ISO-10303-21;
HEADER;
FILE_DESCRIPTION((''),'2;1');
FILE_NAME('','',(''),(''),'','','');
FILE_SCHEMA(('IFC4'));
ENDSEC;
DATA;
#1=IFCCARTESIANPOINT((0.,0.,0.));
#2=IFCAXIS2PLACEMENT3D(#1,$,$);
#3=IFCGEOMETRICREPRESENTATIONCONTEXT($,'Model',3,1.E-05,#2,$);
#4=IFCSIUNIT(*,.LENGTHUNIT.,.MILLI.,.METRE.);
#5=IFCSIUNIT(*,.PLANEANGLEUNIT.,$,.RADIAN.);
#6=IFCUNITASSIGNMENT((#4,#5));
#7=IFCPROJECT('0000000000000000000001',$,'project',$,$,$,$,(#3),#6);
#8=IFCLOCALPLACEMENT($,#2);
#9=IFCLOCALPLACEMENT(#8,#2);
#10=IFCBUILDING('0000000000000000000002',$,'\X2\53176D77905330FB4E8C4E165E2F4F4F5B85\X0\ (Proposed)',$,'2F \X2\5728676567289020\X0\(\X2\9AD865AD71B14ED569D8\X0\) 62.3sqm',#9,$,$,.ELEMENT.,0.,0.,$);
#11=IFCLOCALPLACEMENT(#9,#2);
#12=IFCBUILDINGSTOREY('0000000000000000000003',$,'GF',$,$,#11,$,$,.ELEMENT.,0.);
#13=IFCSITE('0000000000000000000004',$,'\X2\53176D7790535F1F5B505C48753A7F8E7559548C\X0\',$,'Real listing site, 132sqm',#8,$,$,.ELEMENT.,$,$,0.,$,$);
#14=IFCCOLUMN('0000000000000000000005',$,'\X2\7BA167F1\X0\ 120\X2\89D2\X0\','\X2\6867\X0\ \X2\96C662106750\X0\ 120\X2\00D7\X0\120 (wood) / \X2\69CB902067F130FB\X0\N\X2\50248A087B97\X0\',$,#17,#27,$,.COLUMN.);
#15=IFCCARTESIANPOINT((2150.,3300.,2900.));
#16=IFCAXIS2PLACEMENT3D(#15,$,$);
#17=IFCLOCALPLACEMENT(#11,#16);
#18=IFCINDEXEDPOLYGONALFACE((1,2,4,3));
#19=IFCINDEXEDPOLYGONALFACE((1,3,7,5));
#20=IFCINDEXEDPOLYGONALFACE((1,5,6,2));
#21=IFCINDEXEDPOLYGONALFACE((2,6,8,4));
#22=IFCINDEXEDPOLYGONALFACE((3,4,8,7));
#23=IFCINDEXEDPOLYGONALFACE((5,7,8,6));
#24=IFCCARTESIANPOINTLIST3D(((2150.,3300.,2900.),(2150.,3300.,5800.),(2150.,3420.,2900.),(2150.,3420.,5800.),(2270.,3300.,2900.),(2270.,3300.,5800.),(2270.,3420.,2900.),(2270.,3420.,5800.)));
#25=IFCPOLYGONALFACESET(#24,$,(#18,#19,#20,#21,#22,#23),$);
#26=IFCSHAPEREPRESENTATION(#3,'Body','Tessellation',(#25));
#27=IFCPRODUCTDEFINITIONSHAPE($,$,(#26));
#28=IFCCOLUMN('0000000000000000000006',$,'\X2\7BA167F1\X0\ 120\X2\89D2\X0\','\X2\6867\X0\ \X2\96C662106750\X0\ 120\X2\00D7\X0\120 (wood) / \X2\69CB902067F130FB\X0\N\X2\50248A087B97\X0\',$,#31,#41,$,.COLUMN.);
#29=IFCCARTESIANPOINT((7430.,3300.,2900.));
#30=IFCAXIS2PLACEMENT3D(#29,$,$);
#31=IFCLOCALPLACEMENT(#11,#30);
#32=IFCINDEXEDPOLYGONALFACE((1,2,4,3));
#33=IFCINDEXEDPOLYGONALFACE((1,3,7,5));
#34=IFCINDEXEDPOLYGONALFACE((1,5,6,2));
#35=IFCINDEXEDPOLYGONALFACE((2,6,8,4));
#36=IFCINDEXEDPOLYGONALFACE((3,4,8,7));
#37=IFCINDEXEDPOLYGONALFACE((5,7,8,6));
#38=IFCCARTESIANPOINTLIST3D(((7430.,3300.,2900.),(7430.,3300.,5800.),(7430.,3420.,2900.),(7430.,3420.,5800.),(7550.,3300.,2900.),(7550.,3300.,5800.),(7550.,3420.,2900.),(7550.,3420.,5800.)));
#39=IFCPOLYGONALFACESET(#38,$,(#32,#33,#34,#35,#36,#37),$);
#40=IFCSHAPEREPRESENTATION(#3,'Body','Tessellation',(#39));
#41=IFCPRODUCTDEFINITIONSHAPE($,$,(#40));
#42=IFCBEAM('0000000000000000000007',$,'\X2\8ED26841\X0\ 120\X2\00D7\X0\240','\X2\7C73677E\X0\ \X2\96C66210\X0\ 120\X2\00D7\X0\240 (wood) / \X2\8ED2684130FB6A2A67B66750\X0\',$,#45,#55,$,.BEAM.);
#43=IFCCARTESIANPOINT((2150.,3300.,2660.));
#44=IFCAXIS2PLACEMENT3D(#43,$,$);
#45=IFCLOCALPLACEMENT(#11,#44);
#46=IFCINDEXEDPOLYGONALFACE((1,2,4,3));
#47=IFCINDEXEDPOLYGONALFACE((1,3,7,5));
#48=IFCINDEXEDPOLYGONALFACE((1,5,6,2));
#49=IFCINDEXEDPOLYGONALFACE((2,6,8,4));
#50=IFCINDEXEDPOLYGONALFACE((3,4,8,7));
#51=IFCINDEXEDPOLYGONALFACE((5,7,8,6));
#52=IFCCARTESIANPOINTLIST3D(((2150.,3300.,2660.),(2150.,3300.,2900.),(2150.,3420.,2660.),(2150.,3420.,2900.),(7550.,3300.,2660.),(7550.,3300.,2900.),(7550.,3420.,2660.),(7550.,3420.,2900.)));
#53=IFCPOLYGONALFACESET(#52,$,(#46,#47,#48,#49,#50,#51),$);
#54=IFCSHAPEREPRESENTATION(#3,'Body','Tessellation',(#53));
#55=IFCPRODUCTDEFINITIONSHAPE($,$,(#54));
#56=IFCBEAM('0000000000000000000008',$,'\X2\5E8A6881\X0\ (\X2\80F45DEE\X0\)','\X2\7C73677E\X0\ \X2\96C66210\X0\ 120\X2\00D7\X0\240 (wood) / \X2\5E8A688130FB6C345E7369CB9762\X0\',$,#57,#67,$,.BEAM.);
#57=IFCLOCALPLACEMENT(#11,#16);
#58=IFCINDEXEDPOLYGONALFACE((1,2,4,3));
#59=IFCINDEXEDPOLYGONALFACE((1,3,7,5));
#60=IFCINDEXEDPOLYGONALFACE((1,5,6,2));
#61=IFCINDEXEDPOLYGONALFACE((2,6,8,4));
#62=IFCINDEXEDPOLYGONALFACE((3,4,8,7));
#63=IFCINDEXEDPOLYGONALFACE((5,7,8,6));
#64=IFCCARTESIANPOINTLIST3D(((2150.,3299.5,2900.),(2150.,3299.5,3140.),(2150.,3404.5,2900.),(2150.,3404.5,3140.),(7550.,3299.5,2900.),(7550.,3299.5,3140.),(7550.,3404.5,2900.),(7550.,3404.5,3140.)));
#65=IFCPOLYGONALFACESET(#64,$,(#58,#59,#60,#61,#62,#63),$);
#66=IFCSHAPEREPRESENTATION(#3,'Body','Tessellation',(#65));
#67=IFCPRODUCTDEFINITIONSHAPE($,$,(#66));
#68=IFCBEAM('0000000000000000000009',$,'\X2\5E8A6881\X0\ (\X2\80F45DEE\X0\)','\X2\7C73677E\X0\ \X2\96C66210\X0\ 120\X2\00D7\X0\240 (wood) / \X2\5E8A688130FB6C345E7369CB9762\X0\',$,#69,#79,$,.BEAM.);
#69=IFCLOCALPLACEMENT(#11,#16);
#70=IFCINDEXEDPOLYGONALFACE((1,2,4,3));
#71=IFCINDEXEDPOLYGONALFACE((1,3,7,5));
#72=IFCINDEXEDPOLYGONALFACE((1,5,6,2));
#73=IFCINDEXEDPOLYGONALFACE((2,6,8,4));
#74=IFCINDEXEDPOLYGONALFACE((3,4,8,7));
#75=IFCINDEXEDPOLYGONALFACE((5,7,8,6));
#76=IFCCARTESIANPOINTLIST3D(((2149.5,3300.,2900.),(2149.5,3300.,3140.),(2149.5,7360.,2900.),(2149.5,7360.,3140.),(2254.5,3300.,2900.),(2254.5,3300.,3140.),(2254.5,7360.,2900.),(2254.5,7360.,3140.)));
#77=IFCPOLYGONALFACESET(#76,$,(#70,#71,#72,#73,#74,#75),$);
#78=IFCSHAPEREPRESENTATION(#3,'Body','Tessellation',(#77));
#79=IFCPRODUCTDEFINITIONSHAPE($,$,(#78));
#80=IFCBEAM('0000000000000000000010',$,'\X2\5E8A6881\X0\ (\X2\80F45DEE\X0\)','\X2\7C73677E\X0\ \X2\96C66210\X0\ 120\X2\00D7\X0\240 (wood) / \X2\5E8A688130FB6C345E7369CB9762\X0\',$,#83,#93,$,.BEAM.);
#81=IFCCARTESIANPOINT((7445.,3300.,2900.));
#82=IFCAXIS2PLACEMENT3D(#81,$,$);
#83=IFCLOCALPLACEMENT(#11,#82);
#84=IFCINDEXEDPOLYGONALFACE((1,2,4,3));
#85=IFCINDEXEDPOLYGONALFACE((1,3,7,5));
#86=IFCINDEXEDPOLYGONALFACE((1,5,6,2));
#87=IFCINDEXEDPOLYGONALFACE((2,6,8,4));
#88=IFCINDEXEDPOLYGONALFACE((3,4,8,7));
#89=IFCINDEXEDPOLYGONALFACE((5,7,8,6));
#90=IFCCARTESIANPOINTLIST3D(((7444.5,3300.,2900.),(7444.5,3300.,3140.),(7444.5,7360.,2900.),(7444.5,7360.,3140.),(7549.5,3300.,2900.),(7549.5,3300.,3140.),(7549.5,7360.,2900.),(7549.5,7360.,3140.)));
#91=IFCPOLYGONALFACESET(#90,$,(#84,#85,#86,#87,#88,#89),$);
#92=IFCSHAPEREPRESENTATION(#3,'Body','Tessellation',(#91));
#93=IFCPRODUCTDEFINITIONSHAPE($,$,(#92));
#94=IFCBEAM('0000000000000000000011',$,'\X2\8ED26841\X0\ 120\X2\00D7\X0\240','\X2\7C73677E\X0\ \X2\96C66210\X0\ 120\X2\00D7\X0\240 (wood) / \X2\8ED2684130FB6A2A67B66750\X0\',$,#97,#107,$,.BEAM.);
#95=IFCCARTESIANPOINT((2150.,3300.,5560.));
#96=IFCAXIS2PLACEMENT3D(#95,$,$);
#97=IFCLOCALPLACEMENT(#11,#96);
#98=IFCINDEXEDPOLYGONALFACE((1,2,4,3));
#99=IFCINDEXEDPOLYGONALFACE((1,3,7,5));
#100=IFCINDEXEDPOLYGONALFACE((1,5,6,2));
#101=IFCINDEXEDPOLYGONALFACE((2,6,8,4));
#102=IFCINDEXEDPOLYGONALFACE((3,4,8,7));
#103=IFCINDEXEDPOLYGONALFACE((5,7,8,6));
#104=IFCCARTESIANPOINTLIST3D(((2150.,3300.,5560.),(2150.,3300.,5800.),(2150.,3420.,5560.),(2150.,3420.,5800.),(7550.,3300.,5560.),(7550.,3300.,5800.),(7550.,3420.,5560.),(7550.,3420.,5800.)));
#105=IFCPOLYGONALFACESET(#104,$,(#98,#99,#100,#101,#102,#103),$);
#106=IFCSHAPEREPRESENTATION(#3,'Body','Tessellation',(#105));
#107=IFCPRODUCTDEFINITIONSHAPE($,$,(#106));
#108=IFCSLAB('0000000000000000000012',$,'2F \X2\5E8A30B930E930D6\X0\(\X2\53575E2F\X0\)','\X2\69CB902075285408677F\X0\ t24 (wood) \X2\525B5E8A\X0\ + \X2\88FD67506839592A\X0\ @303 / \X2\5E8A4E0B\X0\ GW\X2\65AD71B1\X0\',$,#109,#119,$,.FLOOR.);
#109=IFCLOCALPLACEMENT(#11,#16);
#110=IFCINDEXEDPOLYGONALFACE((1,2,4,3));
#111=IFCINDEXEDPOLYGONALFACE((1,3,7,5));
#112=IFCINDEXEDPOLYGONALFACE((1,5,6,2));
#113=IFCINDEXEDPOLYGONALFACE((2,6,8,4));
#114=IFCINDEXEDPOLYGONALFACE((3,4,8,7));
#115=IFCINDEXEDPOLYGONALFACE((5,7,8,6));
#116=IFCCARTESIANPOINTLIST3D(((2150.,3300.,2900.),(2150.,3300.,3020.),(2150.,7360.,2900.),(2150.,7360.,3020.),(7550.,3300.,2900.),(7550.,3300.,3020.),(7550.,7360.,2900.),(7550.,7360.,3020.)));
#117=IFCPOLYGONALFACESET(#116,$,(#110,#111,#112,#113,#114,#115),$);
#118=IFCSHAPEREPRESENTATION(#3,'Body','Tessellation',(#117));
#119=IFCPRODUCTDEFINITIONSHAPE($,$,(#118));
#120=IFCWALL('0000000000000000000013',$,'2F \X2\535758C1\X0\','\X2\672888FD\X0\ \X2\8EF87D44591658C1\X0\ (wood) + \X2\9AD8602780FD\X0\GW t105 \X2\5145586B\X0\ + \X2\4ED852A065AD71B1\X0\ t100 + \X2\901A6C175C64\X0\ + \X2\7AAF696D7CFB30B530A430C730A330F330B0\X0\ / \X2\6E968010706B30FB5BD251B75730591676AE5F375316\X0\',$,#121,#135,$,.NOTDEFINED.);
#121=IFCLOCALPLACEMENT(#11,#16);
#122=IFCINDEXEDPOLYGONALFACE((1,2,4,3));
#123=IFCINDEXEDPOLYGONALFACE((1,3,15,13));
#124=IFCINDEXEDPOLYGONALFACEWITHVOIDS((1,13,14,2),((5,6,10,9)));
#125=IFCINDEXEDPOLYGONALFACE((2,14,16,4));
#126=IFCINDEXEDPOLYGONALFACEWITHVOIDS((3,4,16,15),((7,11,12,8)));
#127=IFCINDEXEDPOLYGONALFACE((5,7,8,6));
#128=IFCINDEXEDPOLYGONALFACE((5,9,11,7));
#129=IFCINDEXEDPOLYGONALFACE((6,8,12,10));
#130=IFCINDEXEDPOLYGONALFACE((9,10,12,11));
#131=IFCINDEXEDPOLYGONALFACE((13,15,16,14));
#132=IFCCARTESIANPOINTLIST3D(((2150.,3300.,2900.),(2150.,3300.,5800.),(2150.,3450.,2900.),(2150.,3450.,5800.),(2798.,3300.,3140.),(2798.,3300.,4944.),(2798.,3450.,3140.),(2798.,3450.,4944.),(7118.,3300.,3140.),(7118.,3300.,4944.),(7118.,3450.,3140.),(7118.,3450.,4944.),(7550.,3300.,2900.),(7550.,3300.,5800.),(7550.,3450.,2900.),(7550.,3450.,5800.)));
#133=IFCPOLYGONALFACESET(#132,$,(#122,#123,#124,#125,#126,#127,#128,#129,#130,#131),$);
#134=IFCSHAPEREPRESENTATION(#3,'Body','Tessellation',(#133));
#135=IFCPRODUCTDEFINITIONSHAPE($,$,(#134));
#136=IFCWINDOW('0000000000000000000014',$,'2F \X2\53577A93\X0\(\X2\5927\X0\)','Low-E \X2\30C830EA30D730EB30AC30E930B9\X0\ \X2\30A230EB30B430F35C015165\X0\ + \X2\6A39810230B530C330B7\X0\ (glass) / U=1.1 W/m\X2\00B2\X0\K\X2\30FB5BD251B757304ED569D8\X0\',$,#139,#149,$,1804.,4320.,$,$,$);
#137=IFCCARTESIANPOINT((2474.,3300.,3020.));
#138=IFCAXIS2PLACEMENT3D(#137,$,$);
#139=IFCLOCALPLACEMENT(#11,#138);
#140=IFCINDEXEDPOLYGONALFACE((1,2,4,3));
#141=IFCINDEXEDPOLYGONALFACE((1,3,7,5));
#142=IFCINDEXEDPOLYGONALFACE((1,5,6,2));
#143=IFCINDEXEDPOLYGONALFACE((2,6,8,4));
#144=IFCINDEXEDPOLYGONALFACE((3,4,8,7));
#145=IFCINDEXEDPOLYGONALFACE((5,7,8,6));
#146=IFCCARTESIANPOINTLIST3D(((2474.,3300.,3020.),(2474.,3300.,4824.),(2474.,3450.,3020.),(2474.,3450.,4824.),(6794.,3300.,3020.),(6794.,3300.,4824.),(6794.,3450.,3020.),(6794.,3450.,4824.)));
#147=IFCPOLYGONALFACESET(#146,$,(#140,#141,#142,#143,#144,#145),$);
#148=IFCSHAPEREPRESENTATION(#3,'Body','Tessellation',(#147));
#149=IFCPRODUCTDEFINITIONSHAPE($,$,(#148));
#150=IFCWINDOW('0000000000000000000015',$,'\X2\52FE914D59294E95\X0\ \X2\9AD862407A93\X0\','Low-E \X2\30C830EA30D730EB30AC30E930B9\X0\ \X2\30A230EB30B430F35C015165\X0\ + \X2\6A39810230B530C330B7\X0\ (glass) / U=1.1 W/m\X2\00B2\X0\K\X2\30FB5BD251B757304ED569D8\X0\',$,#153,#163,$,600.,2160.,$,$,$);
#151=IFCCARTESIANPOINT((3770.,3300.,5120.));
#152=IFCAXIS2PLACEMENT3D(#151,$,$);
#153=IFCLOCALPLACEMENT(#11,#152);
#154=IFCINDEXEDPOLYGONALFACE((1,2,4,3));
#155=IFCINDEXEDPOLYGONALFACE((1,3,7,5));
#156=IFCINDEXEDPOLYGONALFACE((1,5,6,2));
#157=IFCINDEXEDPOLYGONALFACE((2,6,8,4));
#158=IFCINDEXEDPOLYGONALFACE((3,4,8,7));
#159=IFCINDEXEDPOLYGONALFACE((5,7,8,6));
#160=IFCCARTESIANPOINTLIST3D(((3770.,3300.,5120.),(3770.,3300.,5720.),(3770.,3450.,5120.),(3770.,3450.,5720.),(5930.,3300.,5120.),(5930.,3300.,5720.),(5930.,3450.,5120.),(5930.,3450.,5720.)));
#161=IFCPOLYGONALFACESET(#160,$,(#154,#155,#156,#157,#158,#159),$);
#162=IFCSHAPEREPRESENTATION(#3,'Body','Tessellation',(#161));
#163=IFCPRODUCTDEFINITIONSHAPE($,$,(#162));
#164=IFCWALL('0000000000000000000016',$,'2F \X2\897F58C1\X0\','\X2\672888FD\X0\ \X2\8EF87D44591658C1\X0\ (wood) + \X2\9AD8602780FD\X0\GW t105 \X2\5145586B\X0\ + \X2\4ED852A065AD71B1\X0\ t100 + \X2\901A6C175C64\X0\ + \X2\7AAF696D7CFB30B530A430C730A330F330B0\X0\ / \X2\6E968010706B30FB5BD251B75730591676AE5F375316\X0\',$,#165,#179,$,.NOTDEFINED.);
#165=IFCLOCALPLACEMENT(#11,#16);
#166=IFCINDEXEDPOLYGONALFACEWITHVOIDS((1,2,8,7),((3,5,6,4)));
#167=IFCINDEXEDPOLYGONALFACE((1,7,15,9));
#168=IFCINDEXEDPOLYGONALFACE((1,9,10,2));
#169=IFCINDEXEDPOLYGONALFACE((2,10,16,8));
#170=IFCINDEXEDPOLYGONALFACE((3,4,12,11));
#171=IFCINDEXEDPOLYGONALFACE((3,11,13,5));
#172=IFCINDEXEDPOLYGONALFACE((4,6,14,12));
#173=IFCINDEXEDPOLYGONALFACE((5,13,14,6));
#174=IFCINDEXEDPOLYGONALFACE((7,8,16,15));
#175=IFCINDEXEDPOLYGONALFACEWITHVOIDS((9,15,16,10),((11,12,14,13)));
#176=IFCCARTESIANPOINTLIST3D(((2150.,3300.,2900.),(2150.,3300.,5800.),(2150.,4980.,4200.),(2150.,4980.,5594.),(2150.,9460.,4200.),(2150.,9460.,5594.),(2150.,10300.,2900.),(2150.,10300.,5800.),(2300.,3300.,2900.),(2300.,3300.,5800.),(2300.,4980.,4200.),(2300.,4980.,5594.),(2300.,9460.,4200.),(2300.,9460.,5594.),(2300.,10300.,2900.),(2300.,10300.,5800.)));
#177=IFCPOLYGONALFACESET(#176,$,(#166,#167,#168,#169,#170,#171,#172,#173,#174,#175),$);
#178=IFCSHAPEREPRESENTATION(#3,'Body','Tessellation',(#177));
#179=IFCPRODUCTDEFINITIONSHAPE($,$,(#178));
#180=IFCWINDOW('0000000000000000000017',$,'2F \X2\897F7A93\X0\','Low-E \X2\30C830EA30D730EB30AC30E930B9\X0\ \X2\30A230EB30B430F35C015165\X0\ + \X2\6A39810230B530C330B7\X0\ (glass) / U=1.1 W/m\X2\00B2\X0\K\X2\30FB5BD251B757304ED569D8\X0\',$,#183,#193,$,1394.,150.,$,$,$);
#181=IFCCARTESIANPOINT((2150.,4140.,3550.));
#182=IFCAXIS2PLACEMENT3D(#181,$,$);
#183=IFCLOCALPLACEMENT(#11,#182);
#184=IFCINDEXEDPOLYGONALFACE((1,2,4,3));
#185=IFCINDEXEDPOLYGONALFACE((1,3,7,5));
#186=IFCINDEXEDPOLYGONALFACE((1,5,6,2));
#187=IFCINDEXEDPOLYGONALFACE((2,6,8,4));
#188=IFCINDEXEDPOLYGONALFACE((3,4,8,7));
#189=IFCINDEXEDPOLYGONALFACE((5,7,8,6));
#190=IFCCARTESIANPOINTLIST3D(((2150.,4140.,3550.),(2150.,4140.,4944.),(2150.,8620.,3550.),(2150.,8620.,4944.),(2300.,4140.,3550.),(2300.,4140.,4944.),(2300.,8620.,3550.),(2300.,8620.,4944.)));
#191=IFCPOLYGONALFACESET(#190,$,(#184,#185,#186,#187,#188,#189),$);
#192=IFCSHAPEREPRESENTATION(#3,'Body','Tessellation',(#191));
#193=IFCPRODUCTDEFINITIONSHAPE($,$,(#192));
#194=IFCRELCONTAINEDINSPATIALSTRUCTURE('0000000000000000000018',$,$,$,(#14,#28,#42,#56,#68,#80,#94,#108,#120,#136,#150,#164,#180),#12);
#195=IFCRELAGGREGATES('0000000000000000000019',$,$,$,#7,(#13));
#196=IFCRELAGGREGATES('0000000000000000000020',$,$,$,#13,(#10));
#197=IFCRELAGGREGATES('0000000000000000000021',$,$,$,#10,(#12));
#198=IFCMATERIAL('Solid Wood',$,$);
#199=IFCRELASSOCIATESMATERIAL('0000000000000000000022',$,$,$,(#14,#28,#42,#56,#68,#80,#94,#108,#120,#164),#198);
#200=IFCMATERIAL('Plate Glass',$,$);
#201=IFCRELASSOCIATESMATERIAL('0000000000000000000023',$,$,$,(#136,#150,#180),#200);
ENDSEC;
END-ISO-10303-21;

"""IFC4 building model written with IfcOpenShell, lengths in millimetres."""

from ifc_helpers import new_model, si_unit, frame, frame_2d, origin, place, context, project, spatial, rectangle, extrude, material, element, fill, save


model = new_model("IFC4")

# Units and contexts
model_context = context("Model", 3, precision=1e-05, world=origin())
ifc_project = project(units=[si_unit("LENGTHUNIT", "METRE", prefix="MILLI"), si_unit("PLANEANGLEUNIT", "RADIAN")], contexts=[model_context])

# Site, building, storey
site_placement = place(None, origin())
site = spatial("IfcSite", under=ifc_project, at=site_placement, Name="北海道弟子屈町美留和", ObjectType="Real listing site, 132sqm", CompositionType="ELEMENT", RefElevation=0.0)
building_placement = place(site_placement, origin())
building = spatial("IfcBuilding", under=site, at=building_placement, Name="北海道・二世帯住宅 (Proposed)", ObjectType="2F 在来木造(高断熱仕様) 62.3sqm", CompositionType="ELEMENT", ElevationOfRefHeight=0.0, ElevationOfTerrain=0.0)
storey_placement = place(building_placement, origin())
storey = spatial("IfcBuildingStorey", under=building, at=storey_placement, Name="GF", CompositionType="ELEMENT", Elevation=0.0)

# Columns
ifc_material_1 = material(Name="Solid Wood")
column_1_placement = place(storey_placement, frame((2150.0, 3300.0, 2900.0)))
element("IfcColumn", 1, at=column_1_placement, inside=storey, material=ifc_material_1, Name="管柱 120角", Description="桧 集成材 120×120 (wood) / 構造柱・N値計算", PredefinedType="COLUMN", context=model_context, shape_type="SweptSolid", body=[
    extrude(rectangle(XDim=120.0, YDim=120.0, at=frame_2d((60.0, 60.0))), frame((2150.0, 3300.0, 2900.0)), (0.0, 0.0, 1.0), 2900.0),
])
column_2_placement = place(storey_placement, frame((7430.0, 3300.0, 2900.0)))
element("IfcColumn", 2, at=column_2_placement, inside=storey, material=ifc_material_1, Name="管柱 120角", Description="桧 集成材 120×120 (wood) / 構造柱・N値計算", PredefinedType="COLUMN", context=model_context, shape_type="SweptSolid", body=[
    extrude(rectangle(XDim=120.0, YDim=120.0, at=frame_2d((60.0, 60.0))), frame((7430.0, 3300.0, 2900.0)), (0.0, 0.0, 1.0), 2900.0),
])

# Beams
beam_1_placement = place(storey_placement, frame((2150.0, 3300.0, 2660.0)))
element("IfcBeam", 3, at=beam_1_placement, inside=storey, material=ifc_material_1, Name="軒桁 120×240", Description="米松 集成 120×240 (wood) / 軒桁・横架材", PredefinedType="BEAM", context=model_context, shape_type="SweptSolid", body=[
    extrude(rectangle(XDim=5400.0, YDim=120.0, at=frame_2d((2700.0, 60.0))), frame((2150.0, 3300.0, 2660.0)), (0.0, 0.0, 1.0), 240.0),
])
beam_2_placement = place(storey_placement, frame((2150.0, 3300.0, 2900.0)))
element("IfcBeam", 4, at=beam_2_placement, inside=storey, material=ifc_material_1, Name="床梁 (胴差)", Description="米松 集成 120×240 (wood) / 床梁・水平構面", PredefinedType="BEAM", context=model_context, shape_type="SweptSolid", body=[
    extrude(rectangle(XDim=5400.0, YDim=105.0, at=frame_2d((2700.0, 52.0))), frame((2150.0, 3300.0, 2900.0)), (0.0, 0.0, 1.0), 240.0),
])
beam_3_placement = place(storey_placement, frame((2150.0, 3300.0, 2900.0)))
element("IfcBeam", 5, at=beam_3_placement, inside=storey, material=ifc_material_1, Name="床梁 (胴差)", Description="米松 集成 120×240 (wood) / 床梁・水平構面", PredefinedType="BEAM", context=model_context, shape_type="SweptSolid", body=[
    extrude(rectangle(XDim=105.0, YDim=4060.0, at=frame_2d((52.0, 2030.0))), frame((2150.0, 3300.0, 2900.0)), (0.0, 0.0, 1.0), 240.0),
])
beam_4_placement = place(storey_placement, frame((7445.0, 3300.0, 2900.0)))
element("IfcBeam", 6, at=beam_4_placement, inside=storey, material=ifc_material_1, Name="床梁 (胴差)", Description="米松 集成 120×240 (wood) / 床梁・水平構面", PredefinedType="BEAM", context=model_context, shape_type="SweptSolid", body=[
    extrude(rectangle(XDim=105.0, YDim=4060.0, at=frame_2d((52.0, 2030.0))), frame((7445.0, 3300.0, 2900.0)), (0.0, 0.0, 1.0), 240.0),
])
beam_5_placement = place(storey_placement, frame((2150.0, 3300.0, 5560.0)))
element("IfcBeam", 7, at=beam_5_placement, inside=storey, material=ifc_material_1, Name="軒桁 120×240", Description="米松 集成 120×240 (wood) / 軒桁・横架材", PredefinedType="BEAM", context=model_context, shape_type="SweptSolid", body=[
    extrude(rectangle(XDim=5400.0, YDim=120.0, at=frame_2d((2700.0, 60.0))), frame((2150.0, 3300.0, 5560.0)), (0.0, 0.0, 1.0), 240.0),
])

# Slab
slab_placement = place(storey_placement, frame((2150.0, 3300.0, 2900.0)))
element("IfcSlab", 8, at=slab_placement, inside=storey, material=ifc_material_1, Name="2F 床スラブ(南帯)", Description="構造用合板 t24 (wood) 剛床 + 製材根太 @303 / 床下 GW断熱", PredefinedType="FLOOR", context=model_context, shape_type="SweptSolid", body=[
    extrude(rectangle(XDim=5400.0, YDim=4060.0, at=frame_2d((2700.0, 2030.0))), frame((2150.0, 3300.0, 2900.0)), (0.0, 0.0, 1.0), 120.0),
])

# Wall, openings, windows
wall_1_placement = place(storey_placement, frame((2150.0, 3300.0, 2900.0)))
wall_1 = element("IfcWall", 9, at=wall_1_placement, inside=storey, material=ifc_material_1, Name="2F 南壁", Description="木製 軸組外壁 (wood) + 高性能GW t105 充填 + 付加断熱 t100 + 通気層 + 窯業系サイディング / 準耐火・寒冷地外皮強化", PredefinedType="NOTDEFINED", context=model_context, shape_type="SweptSolid", body=[
    extrude(rectangle(XDim=5400.0, YDim=150.0, at=frame_2d((2700.0, 75.0))), frame((2150.0, 3300.0, 2900.0)), (0.0, 0.0, 1.0), 2900.0),
])
opening_1_placement = place(storey_placement, frame((2474.0, 3300.0, 3020.0)))
opening_1 = element("IfcOpeningElement", 10, at=opening_1_placement, cuts=wall_1, PredefinedType="NOTDEFINED", context=model_context, shape_type="SweptSolid", body=[
    extrude(rectangle(XDim=4320.0, YDim=150.0, at=frame_2d((2160.0, 75.0))), frame((2474.0, 3300.0, 3020.0)), (0.0, 0.0, 1.0), 1804.0),
])
opening_2_placement = place(storey_placement, frame((3770.0, 3300.0, 5120.0)))
opening_2 = element("IfcOpeningElement", 11, at=opening_2_placement, cuts=wall_1, PredefinedType="NOTDEFINED", context=model_context, shape_type="SweptSolid", body=[
    extrude(rectangle(XDim=2160.0, YDim=150.0, at=frame_2d((1080.0, 75.0))), frame((3770.0, 3300.0, 5120.0)), (0.0, 0.0, 1.0), 600.0),
])
ifc_material_2 = material(Name="Plate Glass")
window_1_placement = place(storey_placement, frame((2474.0, 3300.0, 3020.0)))
window_1 = element("IfcWindow", 12, at=window_1_placement, inside=storey, material=ifc_material_2, Name="2F 南窓(大)", Description="Low-E トリプルガラス アルゴン封入 + 樹脂サッシ (glass) / U=1.1 W/m²K・寒冷地仕様", OverallHeight=1804.0, OverallWidth=4320.0, context=model_context, shape_type="SweptSolid", body=[
    extrude(rectangle(XDim=4320.0, YDim=150.0, at=frame_2d((2160.0, 75.0))), frame((2474.0, 3300.0, 3020.0)), (0.0, 0.0, 1.0), 1804.0),
])
fill(opening_1, window_1)
window_2_placement = place(storey_placement, frame((3770.0, 3300.0, 5120.0)))
window_2 = element("IfcWindow", 13, at=window_2_placement, inside=storey, material=ifc_material_2, Name="勾配天井 高所窓", Description="Low-E トリプルガラス アルゴン封入 + 樹脂サッシ (glass) / U=1.1 W/m²K・寒冷地仕様", OverallHeight=600.0, OverallWidth=2160.0, context=model_context, shape_type="SweptSolid", body=[
    extrude(rectangle(XDim=2160.0, YDim=150.0, at=frame_2d((1080.0, 75.0))), frame((3770.0, 3300.0, 5120.0)), (0.0, 0.0, 1.0), 600.0),
])
fill(opening_2, window_2)

# Wall, opening, window
wall_2_placement = place(storey_placement, frame((2150.0, 3300.0, 2900.0)))
wall_2 = element("IfcWall", 14, at=wall_2_placement, inside=storey, material=ifc_material_1, Name="2F 西壁", Description="木製 軸組外壁 (wood) + 高性能GW t105 充填 + 付加断熱 t100 + 通気層 + 窯業系サイディング / 準耐火・寒冷地外皮強化", PredefinedType="NOTDEFINED", context=model_context, shape_type="SweptSolid", body=[
    extrude(rectangle(XDim=150.0, YDim=7000.0, at=frame_2d((75.0, 3500.0))), frame((2150.0, 3300.0, 2900.0)), (0.0, 0.0, 1.0), 2900.0),
])
opening_3_placement = place(storey_placement, frame((2150.0, 4140.0, 3550.0)))
opening_3 = element("IfcOpeningElement", 15, at=opening_3_placement, cuts=wall_2, PredefinedType="NOTDEFINED", context=model_context, shape_type="SweptSolid", body=[
    extrude(rectangle(XDim=150.0, YDim=4480.0, at=frame_2d((75.0, 2240.0))), frame((2150.0, 4140.0, 3550.0)), (0.0, 0.0, 1.0), 1394.0),
])
window_3_placement = place(storey_placement, frame((2150.0, 4140.0, 3550.0)))
window_3 = element("IfcWindow", 16, at=window_3_placement, inside=storey, material=ifc_material_2, Name="2F 西窓", Description="Low-E トリプルガラス アルゴン封入 + 樹脂サッシ (glass) / U=1.1 W/m²K・寒冷地仕様", OverallHeight=1394.0, OverallWidth=150.0, context=model_context, shape_type="SweptSolid", body=[
    extrude(rectangle(XDim=150.0, YDim=4480.0, at=frame_2d((75.0, 2240.0))), frame((2150.0, 4140.0, 3550.0)), (0.0, 0.0, 1.0), 1394.0),
])
fill(opening_3, window_3)

save(model, "model.ifc")
